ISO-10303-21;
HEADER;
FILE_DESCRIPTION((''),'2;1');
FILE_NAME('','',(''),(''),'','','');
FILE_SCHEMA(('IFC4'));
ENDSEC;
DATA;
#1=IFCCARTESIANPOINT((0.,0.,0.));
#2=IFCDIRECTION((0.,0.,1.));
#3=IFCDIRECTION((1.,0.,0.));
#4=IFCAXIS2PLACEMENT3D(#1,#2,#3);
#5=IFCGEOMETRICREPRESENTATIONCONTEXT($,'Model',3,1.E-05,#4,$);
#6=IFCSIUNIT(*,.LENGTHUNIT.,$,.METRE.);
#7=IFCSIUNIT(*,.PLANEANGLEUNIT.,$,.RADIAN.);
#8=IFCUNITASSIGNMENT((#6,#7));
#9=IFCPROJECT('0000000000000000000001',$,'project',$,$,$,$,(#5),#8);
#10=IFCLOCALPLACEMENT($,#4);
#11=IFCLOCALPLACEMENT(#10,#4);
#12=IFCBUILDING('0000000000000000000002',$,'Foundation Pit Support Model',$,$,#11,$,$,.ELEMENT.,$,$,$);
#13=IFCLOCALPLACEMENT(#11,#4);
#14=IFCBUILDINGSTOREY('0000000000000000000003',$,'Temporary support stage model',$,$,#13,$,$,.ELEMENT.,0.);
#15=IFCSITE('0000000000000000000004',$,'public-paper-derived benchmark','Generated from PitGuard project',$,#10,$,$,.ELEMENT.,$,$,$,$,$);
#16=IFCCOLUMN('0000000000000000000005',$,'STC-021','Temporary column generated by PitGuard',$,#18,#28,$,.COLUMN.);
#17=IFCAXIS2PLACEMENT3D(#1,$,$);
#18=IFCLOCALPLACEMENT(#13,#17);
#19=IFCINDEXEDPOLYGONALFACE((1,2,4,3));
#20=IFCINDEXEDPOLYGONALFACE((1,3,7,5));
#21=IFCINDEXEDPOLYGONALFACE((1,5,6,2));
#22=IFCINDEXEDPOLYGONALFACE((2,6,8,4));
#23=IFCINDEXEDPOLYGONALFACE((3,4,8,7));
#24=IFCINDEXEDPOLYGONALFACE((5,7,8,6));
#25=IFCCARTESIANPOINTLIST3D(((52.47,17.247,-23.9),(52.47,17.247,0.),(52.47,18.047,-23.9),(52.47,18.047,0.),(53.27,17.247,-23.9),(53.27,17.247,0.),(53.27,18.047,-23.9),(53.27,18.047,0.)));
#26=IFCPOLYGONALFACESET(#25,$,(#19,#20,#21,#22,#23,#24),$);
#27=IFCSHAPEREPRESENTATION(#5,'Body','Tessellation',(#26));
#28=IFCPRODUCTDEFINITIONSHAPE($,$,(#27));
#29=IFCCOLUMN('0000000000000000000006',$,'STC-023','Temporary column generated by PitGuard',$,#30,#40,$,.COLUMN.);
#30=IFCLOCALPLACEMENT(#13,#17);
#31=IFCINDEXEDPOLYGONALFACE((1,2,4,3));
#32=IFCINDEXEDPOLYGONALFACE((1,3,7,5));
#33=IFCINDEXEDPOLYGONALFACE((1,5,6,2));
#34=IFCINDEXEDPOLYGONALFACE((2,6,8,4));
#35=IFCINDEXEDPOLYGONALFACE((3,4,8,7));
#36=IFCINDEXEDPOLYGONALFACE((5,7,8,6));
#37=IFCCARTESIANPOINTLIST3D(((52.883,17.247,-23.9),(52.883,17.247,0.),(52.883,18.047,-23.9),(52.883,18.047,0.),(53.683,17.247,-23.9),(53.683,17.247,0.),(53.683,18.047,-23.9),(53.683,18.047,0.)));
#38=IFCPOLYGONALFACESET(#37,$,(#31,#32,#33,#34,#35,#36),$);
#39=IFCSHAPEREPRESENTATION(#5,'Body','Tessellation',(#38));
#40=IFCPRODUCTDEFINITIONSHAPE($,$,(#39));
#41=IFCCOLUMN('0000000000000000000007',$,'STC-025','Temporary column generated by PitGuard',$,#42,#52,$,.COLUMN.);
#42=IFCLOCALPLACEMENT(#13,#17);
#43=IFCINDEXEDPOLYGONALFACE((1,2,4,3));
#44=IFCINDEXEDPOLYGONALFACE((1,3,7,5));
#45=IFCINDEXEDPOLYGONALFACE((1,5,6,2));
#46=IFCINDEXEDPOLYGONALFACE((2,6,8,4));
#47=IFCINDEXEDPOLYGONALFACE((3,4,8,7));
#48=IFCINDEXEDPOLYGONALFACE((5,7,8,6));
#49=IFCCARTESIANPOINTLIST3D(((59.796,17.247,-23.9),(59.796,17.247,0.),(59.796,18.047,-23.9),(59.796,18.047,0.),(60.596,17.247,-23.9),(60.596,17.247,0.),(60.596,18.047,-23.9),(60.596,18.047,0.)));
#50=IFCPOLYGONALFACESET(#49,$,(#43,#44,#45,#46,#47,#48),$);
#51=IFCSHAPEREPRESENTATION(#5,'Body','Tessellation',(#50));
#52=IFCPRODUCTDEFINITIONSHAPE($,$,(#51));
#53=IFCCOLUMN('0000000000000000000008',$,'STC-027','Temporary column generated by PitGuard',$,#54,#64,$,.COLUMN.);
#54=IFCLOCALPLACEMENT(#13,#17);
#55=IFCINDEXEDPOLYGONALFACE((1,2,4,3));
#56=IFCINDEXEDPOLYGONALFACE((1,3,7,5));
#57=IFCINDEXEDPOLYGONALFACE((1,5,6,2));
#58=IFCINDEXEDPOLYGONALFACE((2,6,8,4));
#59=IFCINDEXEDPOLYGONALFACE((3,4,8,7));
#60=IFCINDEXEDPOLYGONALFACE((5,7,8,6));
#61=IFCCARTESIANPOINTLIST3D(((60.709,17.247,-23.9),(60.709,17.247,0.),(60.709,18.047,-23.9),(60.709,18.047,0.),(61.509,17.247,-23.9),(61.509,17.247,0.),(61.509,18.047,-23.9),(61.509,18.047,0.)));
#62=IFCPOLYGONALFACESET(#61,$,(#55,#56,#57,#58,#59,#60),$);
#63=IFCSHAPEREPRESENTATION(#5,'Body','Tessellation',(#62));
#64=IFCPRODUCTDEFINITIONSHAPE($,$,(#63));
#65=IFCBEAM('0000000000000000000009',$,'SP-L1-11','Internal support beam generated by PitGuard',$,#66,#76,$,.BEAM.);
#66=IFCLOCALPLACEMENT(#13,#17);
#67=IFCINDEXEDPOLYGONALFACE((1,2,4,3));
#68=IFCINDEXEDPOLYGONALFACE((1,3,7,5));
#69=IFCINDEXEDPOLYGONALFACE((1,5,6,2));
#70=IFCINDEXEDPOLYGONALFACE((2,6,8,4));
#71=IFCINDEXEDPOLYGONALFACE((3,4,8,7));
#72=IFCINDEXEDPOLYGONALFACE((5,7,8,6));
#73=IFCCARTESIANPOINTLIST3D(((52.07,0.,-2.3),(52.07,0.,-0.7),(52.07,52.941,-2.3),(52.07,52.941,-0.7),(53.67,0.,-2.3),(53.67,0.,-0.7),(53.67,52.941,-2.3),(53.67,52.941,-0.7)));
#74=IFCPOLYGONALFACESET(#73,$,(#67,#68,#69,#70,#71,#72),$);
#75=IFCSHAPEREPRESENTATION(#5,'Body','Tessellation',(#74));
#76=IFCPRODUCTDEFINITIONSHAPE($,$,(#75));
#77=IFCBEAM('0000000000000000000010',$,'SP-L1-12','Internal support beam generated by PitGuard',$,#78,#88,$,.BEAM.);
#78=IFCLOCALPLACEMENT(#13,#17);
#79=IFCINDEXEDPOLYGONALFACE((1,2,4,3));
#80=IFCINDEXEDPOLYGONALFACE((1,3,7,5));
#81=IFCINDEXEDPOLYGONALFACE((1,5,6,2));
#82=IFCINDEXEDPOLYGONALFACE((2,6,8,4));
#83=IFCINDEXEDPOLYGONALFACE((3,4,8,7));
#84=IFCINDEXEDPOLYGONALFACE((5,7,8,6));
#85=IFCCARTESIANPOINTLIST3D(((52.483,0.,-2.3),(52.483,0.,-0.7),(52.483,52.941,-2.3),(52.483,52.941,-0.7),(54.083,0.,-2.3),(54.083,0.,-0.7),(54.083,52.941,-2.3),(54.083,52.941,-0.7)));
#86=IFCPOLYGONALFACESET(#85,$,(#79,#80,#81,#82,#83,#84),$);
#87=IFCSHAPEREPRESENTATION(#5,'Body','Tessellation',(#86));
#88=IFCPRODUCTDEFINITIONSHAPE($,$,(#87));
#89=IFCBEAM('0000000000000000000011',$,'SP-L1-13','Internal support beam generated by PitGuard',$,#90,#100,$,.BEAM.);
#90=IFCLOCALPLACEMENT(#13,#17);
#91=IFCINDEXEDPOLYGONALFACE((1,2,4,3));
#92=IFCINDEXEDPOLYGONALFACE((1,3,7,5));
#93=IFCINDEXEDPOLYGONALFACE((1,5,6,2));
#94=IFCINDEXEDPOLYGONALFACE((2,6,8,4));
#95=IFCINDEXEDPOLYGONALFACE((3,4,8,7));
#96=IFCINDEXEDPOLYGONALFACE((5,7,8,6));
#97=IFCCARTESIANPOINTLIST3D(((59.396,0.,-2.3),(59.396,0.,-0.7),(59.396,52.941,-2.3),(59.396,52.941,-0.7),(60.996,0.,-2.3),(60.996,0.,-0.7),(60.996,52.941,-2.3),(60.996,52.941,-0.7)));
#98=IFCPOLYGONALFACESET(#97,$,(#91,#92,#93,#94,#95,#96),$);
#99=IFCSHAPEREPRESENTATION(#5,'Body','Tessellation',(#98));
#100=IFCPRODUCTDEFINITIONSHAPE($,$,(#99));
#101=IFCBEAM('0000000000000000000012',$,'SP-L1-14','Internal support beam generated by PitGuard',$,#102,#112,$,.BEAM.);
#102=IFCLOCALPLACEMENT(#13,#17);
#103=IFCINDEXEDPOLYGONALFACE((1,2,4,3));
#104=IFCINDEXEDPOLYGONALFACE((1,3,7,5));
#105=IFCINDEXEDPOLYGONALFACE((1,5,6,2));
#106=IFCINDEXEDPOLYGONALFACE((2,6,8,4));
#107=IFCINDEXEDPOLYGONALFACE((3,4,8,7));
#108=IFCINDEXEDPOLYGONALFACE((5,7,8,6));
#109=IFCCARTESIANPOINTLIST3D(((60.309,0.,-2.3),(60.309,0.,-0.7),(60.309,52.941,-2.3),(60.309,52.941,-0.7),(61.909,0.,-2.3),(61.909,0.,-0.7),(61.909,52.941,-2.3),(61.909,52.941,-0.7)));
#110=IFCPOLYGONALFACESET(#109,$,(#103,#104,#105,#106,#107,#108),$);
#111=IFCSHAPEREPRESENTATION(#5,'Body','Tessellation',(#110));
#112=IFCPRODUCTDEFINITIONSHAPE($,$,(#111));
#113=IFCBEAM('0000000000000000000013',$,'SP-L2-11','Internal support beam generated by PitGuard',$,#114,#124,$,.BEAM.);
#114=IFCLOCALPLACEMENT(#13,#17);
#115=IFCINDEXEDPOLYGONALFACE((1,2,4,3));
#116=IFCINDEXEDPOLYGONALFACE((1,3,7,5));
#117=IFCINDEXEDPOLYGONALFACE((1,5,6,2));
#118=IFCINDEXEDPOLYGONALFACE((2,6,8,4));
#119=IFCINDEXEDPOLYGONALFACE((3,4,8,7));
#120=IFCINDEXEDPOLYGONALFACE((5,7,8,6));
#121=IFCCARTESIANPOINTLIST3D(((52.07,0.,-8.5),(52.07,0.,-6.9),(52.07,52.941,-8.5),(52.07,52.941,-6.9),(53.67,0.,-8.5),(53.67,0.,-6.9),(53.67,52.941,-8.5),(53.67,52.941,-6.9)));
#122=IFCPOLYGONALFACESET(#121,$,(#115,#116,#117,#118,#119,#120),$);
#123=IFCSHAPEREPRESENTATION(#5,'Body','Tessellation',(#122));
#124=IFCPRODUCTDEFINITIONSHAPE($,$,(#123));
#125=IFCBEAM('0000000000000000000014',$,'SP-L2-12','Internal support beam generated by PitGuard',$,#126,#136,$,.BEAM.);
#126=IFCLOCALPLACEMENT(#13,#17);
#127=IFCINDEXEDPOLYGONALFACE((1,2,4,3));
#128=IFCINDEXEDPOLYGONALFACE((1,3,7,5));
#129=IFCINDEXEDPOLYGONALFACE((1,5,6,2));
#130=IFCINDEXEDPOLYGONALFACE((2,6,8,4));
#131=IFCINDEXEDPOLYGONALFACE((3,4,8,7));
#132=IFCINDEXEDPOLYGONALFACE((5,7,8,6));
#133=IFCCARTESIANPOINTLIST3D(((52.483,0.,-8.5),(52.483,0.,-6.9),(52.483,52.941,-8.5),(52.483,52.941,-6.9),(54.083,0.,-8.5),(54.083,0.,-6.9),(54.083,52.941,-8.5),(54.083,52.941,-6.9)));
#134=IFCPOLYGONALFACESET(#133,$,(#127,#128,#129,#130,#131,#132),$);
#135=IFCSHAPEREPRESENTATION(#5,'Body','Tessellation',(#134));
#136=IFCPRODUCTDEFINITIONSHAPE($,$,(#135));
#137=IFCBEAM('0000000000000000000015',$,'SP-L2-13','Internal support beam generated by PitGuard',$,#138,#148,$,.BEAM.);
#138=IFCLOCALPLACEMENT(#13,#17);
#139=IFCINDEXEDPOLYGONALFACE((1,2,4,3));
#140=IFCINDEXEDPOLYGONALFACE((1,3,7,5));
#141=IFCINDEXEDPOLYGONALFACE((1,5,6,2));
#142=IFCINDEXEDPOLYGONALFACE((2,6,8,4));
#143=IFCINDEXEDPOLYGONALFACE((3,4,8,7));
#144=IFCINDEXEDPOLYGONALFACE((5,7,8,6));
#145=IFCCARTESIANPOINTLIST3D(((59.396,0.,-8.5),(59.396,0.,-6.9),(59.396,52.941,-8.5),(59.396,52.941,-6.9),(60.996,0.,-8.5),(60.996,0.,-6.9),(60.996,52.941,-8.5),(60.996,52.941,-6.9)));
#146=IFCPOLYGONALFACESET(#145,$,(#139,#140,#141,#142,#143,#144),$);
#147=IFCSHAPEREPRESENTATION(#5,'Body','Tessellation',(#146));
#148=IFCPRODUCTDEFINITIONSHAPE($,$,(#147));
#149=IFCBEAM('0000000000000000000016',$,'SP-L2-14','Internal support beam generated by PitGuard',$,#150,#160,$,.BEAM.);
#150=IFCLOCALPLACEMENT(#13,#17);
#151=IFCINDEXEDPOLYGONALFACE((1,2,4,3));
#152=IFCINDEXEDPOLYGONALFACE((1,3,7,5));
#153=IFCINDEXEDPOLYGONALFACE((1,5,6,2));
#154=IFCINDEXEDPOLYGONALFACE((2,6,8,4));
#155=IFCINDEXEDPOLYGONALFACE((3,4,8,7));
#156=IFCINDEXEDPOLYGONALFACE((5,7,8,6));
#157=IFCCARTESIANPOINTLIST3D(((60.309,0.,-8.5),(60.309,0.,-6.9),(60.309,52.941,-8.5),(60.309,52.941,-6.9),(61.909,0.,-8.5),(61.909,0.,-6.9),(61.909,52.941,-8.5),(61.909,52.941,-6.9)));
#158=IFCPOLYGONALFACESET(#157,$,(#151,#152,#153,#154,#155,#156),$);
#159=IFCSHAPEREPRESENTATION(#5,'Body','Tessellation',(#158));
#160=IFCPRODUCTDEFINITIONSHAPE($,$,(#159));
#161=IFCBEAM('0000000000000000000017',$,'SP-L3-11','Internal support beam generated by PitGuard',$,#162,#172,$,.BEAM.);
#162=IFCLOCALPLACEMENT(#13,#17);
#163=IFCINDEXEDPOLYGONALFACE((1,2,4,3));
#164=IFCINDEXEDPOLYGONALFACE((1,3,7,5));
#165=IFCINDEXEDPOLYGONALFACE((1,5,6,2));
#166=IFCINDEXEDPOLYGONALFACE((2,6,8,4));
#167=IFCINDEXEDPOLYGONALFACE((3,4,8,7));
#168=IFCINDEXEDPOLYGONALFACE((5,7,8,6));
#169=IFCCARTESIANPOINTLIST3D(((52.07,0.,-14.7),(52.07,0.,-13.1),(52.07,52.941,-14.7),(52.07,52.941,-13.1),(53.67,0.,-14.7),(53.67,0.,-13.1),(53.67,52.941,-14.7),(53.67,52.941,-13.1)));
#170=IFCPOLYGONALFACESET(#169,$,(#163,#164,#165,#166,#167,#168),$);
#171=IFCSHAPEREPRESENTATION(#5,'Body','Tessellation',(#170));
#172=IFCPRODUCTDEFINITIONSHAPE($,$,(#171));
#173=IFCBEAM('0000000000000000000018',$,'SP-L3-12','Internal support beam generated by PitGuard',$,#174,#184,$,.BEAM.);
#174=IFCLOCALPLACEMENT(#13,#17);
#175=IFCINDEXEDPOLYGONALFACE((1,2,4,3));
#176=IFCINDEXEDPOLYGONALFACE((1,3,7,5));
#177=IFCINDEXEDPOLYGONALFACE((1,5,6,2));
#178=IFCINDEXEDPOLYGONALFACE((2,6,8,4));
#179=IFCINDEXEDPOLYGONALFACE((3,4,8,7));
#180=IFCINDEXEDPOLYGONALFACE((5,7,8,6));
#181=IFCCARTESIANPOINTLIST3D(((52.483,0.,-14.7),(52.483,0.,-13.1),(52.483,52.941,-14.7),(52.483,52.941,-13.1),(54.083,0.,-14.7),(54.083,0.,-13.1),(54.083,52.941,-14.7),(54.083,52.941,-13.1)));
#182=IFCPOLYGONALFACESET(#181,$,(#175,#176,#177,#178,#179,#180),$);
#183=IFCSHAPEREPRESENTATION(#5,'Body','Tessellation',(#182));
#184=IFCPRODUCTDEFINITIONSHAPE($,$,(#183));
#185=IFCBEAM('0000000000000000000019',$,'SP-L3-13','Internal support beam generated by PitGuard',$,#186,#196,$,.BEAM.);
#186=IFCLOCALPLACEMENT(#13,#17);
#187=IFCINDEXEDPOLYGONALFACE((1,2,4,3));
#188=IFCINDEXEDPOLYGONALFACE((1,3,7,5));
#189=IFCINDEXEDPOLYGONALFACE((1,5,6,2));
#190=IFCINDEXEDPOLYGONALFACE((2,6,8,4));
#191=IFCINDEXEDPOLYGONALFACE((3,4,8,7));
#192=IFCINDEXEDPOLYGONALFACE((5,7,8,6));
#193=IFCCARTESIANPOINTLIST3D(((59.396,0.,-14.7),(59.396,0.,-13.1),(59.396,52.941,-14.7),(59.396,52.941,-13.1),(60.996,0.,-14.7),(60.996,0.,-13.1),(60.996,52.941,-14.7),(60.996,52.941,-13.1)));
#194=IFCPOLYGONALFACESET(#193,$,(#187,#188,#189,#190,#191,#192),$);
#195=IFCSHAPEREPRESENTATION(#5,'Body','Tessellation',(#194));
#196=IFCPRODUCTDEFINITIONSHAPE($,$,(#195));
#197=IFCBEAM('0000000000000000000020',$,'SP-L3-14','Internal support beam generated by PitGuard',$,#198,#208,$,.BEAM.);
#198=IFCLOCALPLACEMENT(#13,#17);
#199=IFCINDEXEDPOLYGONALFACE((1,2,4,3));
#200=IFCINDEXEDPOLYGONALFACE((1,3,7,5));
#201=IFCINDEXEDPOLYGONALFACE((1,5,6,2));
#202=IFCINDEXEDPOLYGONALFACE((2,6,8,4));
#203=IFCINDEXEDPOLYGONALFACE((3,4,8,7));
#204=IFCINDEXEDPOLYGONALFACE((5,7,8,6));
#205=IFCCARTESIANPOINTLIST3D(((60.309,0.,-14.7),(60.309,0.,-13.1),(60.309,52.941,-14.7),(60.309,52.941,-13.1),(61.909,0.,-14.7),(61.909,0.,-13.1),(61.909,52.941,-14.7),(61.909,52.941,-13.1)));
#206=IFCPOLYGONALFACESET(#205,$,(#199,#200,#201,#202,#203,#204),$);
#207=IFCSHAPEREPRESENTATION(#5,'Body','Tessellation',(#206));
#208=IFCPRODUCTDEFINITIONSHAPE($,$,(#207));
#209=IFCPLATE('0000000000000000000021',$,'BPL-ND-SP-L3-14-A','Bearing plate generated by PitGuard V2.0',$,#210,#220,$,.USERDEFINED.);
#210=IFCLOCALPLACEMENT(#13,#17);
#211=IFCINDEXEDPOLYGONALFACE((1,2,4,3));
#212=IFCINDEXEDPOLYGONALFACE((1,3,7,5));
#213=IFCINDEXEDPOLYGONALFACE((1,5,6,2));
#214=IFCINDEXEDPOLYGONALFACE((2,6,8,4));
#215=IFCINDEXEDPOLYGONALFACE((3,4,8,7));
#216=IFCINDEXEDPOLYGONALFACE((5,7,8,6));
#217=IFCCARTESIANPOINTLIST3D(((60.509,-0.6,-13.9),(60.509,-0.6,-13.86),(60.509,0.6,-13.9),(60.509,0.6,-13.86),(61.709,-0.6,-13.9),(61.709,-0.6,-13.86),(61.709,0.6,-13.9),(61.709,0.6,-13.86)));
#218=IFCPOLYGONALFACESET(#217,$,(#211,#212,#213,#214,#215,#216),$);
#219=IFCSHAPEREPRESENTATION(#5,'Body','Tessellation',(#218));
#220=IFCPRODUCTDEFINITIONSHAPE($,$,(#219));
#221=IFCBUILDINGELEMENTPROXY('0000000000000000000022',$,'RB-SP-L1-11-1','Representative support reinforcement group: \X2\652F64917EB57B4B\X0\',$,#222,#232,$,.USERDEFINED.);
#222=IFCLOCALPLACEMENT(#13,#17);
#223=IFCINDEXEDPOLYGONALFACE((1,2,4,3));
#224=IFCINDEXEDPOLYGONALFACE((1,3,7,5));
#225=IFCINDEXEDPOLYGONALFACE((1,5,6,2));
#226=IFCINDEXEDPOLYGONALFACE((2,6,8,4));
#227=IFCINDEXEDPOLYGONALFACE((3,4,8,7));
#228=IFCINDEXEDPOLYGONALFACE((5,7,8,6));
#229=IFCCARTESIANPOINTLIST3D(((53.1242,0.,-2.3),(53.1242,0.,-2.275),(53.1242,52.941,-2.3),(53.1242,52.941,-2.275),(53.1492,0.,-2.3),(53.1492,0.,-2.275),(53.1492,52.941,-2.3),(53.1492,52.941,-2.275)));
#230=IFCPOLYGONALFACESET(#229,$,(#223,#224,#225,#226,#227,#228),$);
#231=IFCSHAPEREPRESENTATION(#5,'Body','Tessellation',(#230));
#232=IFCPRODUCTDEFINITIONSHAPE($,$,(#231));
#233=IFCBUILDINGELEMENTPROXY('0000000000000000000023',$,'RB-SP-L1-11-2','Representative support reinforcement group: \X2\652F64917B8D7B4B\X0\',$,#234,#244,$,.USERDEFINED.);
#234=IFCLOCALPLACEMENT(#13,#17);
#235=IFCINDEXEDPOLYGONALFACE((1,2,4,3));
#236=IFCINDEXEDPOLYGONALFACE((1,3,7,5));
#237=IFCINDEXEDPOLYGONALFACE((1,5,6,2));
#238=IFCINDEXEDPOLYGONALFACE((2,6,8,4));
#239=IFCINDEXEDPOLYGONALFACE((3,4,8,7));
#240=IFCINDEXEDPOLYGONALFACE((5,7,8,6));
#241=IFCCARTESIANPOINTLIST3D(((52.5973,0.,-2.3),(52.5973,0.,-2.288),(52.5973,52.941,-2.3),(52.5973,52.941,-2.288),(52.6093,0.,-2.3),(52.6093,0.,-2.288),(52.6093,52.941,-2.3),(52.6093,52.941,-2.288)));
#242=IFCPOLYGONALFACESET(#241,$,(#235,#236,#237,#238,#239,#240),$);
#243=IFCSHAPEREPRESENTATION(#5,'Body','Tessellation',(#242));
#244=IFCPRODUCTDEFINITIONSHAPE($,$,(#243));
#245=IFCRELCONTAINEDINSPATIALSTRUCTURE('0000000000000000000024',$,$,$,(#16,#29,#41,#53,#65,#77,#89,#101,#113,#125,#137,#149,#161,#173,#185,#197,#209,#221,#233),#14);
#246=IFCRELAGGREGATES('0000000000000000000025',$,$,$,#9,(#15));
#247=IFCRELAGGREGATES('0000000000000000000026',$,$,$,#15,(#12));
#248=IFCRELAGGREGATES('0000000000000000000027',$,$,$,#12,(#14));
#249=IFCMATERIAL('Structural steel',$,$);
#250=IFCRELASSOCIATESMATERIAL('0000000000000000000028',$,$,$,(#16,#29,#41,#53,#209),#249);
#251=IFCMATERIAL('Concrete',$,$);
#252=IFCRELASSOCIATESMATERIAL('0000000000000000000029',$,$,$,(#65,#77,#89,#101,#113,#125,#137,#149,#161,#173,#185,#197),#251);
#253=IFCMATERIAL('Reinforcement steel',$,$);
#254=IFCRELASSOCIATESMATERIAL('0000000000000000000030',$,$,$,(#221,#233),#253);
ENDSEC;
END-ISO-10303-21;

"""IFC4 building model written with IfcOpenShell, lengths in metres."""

from ifc_helpers import new_model, si_unit, frame, origin_with_axes, origin_2d, place, context, project, spatial, rectangle, extrude, material, element, save


model = new_model("IFC4")

# Units and contexts
model_context = context("Model", 3, precision=1e-05, world=origin_with_axes())
ifc_project = project(units=[si_unit("LENGTHUNIT", "METRE"), si_unit("PLANEANGLEUNIT", "RADIAN")], contexts=[model_context])

# Site, building, storey
site_placement = place(None, origin_with_axes())
site = spatial("IfcSite", under=ifc_project, at=site_placement, Name="public-paper-derived benchmark", Description="Generated from PitGuard project", CompositionType="ELEMENT")
building_placement = place(site_placement, origin_with_axes())
building = spatial("IfcBuilding", under=site, at=building_placement, Name="Foundation Pit Support Model", CompositionType="ELEMENT")
storey_placement = place(building_placement, origin_with_axes())
storey = spatial("IfcBuildingStorey", under=building, at=storey_placement, Name="Temporary support stage model", CompositionType="ELEMENT", Elevation=0.0)

# Columns
ifc_material_1 = material(Name="Structural steel")
for number, where, z_axis, x_axis, name in (
    (1, (52.87, 17.647, -23.9), (0.0, 0.0, 1.0), (1.0, 0.0, 0.0), "STC-021"),
    (2, (53.283, 17.647, -23.9), (0.0, 0.0, 1.0), (1.0, 0.0, 0.0), "STC-023"),
    (3, (60.196, 17.647, -23.9), (0.0, 0.0, 1.0), (1.0, 0.0, 0.0), "STC-025"),
    (4, (61.109, 17.647, -23.9), (0.0, 0.0, 1.0), (1.0, 0.0, 0.0), "STC-027"),
):
    element("IfcColumn", number, at=place(storey_placement, frame(where, z_axis=z_axis, x_axis=x_axis)), inside=storey, material=ifc_material_1, Name=name, Description="Temporary column generated by PitGuard", PredefinedType="COLUMN", context=model_context, shape_type="SweptSolid", body=[
        extrude(rectangle(XDim=0.8, YDim=0.8, at=origin_2d()), origin_with_axes(), (0.0, 0.0, 1.0), 23.9),
    ])

# Beams
ifc_material_2 = material(Name="Concrete")
for number, where, z_axis, x_axis, name in (
    (5, (52.87, 26.4705, -2.3), (0.0, 0.0, 1.0), (0.0, 1.0, 0.0), "SP-L1-11"),
    (6, (53.283, 26.4705, -2.3), (0.0, 0.0, 1.0), (0.0, 1.0, 0.0), "SP-L1-12"),
    (7, (60.196, 26.4705, -2.3), (0.0, 0.0, 1.0), (0.0, 1.0, 0.0), "SP-L1-13"),
    (8, (61.109, 26.4705, -2.3), (0.0, 0.0, 1.0), (0.0, 1.0, 0.0), "SP-L1-14"),
    (9, (52.87, 26.4705, -8.5), (0.0, 0.0, 1.0), (0.0, 1.0, 0.0), "SP-L2-11"),
    (10, (53.283, 26.4705, -8.5), (0.0, 0.0, 1.0), (0.0, 1.0, 0.0), "SP-L2-12"),
    (11, (60.196, 26.4705, -8.5), (0.0, 0.0, 1.0), (0.0, 1.0, 0.0), "SP-L2-13"),
    (12, (61.109, 26.4705, -8.5), (0.0, 0.0, 1.0), (0.0, 1.0, 0.0), "SP-L2-14"),
    (13, (52.87, 26.4705, -14.7), (0.0, 0.0, 1.0), (0.0, 1.0, 0.0), "SP-L3-11"),
    (14, (53.283, 26.4705, -14.7), (0.0, 0.0, 1.0), (0.0, 1.0, 0.0), "SP-L3-12"),
    (15, (60.196, 26.4705, -14.7), (0.0, 0.0, 1.0), (0.0, 1.0, 0.0), "SP-L3-13"),
    (16, (61.109, 26.4705, -14.7), (0.0, 0.0, 1.0), (0.0, 1.0, 0.0), "SP-L3-14"),
):
    element("IfcBeam", number, at=place(storey_placement, frame(where, z_axis=z_axis, x_axis=x_axis)), inside=storey, material=ifc_material_2, Name=name, Description="Internal support beam generated by PitGuard", PredefinedType="BEAM", context=model_context, shape_type="SweptSolid", body=[
        extrude(rectangle(XDim=52.941, YDim=1.6, at=origin_2d()), origin_with_axes(), (0.0, 0.0, 1.0), 1.6),
    ])

# Plate
plate_placement = place(storey_placement, frame((61.109, 0.0, -13.9), z_axis=(0.0, 0.0, 1.0), x_axis=(1.0, 0.0, 0.0)))
element("IfcPlate", 17, at=plate_placement, inside=storey, material=ifc_material_1, Name="BPL-ND-SP-L3-14-A", Description="Bearing plate generated by PitGuard V2.0", PredefinedType="USERDEFINED", context=model_context, shape_type="SweptSolid", body=[
    extrude(rectangle(XDim=1.2, YDim=1.2, at=origin_2d()), origin_with_axes(), (0.0, 0.0, 1.0), 0.04),
])

# Building element proxies
ifc_material_3 = material(Name="Reinforcement steel")
proxy_1_placement = place(storey_placement, frame((53.1367, 26.4705, -2.3), z_axis=(0.0, 0.0, 1.0), x_axis=(0.0, 1.0, 0.0)))
element("IfcBuildingElementProxy", 18, at=proxy_1_placement, inside=storey, material=ifc_material_3, Name="RB-SP-L1-11-1", Description="Representative support reinforcement group: 支撑纵筋", PredefinedType="USERDEFINED", context=model_context, shape_type="SweptSolid", body=[
    extrude(rectangle(XDim=52.941, YDim=0.025, at=origin_2d()), origin_with_axes(), (0.0, 0.0, 1.0), 0.025),
])
proxy_2_placement = place(storey_placement, frame((52.6033, 26.4705, -2.3), z_axis=(0.0, 0.0, 1.0), x_axis=(0.0, 1.0, 0.0)))
element("IfcBuildingElementProxy", 19, at=proxy_2_placement, inside=storey, material=ifc_material_3, Name="RB-SP-L1-11-2", Description="Representative support reinforcement group: 支撑箍筋", PredefinedType="USERDEFINED", context=model_context, shape_type="SweptSolid", body=[
    extrude(rectangle(XDim=52.941, YDim=0.012, at=origin_2d()), origin_with_axes(), (0.0, 0.0, 1.0), 0.012),
])

save(model, "model.ifc")
